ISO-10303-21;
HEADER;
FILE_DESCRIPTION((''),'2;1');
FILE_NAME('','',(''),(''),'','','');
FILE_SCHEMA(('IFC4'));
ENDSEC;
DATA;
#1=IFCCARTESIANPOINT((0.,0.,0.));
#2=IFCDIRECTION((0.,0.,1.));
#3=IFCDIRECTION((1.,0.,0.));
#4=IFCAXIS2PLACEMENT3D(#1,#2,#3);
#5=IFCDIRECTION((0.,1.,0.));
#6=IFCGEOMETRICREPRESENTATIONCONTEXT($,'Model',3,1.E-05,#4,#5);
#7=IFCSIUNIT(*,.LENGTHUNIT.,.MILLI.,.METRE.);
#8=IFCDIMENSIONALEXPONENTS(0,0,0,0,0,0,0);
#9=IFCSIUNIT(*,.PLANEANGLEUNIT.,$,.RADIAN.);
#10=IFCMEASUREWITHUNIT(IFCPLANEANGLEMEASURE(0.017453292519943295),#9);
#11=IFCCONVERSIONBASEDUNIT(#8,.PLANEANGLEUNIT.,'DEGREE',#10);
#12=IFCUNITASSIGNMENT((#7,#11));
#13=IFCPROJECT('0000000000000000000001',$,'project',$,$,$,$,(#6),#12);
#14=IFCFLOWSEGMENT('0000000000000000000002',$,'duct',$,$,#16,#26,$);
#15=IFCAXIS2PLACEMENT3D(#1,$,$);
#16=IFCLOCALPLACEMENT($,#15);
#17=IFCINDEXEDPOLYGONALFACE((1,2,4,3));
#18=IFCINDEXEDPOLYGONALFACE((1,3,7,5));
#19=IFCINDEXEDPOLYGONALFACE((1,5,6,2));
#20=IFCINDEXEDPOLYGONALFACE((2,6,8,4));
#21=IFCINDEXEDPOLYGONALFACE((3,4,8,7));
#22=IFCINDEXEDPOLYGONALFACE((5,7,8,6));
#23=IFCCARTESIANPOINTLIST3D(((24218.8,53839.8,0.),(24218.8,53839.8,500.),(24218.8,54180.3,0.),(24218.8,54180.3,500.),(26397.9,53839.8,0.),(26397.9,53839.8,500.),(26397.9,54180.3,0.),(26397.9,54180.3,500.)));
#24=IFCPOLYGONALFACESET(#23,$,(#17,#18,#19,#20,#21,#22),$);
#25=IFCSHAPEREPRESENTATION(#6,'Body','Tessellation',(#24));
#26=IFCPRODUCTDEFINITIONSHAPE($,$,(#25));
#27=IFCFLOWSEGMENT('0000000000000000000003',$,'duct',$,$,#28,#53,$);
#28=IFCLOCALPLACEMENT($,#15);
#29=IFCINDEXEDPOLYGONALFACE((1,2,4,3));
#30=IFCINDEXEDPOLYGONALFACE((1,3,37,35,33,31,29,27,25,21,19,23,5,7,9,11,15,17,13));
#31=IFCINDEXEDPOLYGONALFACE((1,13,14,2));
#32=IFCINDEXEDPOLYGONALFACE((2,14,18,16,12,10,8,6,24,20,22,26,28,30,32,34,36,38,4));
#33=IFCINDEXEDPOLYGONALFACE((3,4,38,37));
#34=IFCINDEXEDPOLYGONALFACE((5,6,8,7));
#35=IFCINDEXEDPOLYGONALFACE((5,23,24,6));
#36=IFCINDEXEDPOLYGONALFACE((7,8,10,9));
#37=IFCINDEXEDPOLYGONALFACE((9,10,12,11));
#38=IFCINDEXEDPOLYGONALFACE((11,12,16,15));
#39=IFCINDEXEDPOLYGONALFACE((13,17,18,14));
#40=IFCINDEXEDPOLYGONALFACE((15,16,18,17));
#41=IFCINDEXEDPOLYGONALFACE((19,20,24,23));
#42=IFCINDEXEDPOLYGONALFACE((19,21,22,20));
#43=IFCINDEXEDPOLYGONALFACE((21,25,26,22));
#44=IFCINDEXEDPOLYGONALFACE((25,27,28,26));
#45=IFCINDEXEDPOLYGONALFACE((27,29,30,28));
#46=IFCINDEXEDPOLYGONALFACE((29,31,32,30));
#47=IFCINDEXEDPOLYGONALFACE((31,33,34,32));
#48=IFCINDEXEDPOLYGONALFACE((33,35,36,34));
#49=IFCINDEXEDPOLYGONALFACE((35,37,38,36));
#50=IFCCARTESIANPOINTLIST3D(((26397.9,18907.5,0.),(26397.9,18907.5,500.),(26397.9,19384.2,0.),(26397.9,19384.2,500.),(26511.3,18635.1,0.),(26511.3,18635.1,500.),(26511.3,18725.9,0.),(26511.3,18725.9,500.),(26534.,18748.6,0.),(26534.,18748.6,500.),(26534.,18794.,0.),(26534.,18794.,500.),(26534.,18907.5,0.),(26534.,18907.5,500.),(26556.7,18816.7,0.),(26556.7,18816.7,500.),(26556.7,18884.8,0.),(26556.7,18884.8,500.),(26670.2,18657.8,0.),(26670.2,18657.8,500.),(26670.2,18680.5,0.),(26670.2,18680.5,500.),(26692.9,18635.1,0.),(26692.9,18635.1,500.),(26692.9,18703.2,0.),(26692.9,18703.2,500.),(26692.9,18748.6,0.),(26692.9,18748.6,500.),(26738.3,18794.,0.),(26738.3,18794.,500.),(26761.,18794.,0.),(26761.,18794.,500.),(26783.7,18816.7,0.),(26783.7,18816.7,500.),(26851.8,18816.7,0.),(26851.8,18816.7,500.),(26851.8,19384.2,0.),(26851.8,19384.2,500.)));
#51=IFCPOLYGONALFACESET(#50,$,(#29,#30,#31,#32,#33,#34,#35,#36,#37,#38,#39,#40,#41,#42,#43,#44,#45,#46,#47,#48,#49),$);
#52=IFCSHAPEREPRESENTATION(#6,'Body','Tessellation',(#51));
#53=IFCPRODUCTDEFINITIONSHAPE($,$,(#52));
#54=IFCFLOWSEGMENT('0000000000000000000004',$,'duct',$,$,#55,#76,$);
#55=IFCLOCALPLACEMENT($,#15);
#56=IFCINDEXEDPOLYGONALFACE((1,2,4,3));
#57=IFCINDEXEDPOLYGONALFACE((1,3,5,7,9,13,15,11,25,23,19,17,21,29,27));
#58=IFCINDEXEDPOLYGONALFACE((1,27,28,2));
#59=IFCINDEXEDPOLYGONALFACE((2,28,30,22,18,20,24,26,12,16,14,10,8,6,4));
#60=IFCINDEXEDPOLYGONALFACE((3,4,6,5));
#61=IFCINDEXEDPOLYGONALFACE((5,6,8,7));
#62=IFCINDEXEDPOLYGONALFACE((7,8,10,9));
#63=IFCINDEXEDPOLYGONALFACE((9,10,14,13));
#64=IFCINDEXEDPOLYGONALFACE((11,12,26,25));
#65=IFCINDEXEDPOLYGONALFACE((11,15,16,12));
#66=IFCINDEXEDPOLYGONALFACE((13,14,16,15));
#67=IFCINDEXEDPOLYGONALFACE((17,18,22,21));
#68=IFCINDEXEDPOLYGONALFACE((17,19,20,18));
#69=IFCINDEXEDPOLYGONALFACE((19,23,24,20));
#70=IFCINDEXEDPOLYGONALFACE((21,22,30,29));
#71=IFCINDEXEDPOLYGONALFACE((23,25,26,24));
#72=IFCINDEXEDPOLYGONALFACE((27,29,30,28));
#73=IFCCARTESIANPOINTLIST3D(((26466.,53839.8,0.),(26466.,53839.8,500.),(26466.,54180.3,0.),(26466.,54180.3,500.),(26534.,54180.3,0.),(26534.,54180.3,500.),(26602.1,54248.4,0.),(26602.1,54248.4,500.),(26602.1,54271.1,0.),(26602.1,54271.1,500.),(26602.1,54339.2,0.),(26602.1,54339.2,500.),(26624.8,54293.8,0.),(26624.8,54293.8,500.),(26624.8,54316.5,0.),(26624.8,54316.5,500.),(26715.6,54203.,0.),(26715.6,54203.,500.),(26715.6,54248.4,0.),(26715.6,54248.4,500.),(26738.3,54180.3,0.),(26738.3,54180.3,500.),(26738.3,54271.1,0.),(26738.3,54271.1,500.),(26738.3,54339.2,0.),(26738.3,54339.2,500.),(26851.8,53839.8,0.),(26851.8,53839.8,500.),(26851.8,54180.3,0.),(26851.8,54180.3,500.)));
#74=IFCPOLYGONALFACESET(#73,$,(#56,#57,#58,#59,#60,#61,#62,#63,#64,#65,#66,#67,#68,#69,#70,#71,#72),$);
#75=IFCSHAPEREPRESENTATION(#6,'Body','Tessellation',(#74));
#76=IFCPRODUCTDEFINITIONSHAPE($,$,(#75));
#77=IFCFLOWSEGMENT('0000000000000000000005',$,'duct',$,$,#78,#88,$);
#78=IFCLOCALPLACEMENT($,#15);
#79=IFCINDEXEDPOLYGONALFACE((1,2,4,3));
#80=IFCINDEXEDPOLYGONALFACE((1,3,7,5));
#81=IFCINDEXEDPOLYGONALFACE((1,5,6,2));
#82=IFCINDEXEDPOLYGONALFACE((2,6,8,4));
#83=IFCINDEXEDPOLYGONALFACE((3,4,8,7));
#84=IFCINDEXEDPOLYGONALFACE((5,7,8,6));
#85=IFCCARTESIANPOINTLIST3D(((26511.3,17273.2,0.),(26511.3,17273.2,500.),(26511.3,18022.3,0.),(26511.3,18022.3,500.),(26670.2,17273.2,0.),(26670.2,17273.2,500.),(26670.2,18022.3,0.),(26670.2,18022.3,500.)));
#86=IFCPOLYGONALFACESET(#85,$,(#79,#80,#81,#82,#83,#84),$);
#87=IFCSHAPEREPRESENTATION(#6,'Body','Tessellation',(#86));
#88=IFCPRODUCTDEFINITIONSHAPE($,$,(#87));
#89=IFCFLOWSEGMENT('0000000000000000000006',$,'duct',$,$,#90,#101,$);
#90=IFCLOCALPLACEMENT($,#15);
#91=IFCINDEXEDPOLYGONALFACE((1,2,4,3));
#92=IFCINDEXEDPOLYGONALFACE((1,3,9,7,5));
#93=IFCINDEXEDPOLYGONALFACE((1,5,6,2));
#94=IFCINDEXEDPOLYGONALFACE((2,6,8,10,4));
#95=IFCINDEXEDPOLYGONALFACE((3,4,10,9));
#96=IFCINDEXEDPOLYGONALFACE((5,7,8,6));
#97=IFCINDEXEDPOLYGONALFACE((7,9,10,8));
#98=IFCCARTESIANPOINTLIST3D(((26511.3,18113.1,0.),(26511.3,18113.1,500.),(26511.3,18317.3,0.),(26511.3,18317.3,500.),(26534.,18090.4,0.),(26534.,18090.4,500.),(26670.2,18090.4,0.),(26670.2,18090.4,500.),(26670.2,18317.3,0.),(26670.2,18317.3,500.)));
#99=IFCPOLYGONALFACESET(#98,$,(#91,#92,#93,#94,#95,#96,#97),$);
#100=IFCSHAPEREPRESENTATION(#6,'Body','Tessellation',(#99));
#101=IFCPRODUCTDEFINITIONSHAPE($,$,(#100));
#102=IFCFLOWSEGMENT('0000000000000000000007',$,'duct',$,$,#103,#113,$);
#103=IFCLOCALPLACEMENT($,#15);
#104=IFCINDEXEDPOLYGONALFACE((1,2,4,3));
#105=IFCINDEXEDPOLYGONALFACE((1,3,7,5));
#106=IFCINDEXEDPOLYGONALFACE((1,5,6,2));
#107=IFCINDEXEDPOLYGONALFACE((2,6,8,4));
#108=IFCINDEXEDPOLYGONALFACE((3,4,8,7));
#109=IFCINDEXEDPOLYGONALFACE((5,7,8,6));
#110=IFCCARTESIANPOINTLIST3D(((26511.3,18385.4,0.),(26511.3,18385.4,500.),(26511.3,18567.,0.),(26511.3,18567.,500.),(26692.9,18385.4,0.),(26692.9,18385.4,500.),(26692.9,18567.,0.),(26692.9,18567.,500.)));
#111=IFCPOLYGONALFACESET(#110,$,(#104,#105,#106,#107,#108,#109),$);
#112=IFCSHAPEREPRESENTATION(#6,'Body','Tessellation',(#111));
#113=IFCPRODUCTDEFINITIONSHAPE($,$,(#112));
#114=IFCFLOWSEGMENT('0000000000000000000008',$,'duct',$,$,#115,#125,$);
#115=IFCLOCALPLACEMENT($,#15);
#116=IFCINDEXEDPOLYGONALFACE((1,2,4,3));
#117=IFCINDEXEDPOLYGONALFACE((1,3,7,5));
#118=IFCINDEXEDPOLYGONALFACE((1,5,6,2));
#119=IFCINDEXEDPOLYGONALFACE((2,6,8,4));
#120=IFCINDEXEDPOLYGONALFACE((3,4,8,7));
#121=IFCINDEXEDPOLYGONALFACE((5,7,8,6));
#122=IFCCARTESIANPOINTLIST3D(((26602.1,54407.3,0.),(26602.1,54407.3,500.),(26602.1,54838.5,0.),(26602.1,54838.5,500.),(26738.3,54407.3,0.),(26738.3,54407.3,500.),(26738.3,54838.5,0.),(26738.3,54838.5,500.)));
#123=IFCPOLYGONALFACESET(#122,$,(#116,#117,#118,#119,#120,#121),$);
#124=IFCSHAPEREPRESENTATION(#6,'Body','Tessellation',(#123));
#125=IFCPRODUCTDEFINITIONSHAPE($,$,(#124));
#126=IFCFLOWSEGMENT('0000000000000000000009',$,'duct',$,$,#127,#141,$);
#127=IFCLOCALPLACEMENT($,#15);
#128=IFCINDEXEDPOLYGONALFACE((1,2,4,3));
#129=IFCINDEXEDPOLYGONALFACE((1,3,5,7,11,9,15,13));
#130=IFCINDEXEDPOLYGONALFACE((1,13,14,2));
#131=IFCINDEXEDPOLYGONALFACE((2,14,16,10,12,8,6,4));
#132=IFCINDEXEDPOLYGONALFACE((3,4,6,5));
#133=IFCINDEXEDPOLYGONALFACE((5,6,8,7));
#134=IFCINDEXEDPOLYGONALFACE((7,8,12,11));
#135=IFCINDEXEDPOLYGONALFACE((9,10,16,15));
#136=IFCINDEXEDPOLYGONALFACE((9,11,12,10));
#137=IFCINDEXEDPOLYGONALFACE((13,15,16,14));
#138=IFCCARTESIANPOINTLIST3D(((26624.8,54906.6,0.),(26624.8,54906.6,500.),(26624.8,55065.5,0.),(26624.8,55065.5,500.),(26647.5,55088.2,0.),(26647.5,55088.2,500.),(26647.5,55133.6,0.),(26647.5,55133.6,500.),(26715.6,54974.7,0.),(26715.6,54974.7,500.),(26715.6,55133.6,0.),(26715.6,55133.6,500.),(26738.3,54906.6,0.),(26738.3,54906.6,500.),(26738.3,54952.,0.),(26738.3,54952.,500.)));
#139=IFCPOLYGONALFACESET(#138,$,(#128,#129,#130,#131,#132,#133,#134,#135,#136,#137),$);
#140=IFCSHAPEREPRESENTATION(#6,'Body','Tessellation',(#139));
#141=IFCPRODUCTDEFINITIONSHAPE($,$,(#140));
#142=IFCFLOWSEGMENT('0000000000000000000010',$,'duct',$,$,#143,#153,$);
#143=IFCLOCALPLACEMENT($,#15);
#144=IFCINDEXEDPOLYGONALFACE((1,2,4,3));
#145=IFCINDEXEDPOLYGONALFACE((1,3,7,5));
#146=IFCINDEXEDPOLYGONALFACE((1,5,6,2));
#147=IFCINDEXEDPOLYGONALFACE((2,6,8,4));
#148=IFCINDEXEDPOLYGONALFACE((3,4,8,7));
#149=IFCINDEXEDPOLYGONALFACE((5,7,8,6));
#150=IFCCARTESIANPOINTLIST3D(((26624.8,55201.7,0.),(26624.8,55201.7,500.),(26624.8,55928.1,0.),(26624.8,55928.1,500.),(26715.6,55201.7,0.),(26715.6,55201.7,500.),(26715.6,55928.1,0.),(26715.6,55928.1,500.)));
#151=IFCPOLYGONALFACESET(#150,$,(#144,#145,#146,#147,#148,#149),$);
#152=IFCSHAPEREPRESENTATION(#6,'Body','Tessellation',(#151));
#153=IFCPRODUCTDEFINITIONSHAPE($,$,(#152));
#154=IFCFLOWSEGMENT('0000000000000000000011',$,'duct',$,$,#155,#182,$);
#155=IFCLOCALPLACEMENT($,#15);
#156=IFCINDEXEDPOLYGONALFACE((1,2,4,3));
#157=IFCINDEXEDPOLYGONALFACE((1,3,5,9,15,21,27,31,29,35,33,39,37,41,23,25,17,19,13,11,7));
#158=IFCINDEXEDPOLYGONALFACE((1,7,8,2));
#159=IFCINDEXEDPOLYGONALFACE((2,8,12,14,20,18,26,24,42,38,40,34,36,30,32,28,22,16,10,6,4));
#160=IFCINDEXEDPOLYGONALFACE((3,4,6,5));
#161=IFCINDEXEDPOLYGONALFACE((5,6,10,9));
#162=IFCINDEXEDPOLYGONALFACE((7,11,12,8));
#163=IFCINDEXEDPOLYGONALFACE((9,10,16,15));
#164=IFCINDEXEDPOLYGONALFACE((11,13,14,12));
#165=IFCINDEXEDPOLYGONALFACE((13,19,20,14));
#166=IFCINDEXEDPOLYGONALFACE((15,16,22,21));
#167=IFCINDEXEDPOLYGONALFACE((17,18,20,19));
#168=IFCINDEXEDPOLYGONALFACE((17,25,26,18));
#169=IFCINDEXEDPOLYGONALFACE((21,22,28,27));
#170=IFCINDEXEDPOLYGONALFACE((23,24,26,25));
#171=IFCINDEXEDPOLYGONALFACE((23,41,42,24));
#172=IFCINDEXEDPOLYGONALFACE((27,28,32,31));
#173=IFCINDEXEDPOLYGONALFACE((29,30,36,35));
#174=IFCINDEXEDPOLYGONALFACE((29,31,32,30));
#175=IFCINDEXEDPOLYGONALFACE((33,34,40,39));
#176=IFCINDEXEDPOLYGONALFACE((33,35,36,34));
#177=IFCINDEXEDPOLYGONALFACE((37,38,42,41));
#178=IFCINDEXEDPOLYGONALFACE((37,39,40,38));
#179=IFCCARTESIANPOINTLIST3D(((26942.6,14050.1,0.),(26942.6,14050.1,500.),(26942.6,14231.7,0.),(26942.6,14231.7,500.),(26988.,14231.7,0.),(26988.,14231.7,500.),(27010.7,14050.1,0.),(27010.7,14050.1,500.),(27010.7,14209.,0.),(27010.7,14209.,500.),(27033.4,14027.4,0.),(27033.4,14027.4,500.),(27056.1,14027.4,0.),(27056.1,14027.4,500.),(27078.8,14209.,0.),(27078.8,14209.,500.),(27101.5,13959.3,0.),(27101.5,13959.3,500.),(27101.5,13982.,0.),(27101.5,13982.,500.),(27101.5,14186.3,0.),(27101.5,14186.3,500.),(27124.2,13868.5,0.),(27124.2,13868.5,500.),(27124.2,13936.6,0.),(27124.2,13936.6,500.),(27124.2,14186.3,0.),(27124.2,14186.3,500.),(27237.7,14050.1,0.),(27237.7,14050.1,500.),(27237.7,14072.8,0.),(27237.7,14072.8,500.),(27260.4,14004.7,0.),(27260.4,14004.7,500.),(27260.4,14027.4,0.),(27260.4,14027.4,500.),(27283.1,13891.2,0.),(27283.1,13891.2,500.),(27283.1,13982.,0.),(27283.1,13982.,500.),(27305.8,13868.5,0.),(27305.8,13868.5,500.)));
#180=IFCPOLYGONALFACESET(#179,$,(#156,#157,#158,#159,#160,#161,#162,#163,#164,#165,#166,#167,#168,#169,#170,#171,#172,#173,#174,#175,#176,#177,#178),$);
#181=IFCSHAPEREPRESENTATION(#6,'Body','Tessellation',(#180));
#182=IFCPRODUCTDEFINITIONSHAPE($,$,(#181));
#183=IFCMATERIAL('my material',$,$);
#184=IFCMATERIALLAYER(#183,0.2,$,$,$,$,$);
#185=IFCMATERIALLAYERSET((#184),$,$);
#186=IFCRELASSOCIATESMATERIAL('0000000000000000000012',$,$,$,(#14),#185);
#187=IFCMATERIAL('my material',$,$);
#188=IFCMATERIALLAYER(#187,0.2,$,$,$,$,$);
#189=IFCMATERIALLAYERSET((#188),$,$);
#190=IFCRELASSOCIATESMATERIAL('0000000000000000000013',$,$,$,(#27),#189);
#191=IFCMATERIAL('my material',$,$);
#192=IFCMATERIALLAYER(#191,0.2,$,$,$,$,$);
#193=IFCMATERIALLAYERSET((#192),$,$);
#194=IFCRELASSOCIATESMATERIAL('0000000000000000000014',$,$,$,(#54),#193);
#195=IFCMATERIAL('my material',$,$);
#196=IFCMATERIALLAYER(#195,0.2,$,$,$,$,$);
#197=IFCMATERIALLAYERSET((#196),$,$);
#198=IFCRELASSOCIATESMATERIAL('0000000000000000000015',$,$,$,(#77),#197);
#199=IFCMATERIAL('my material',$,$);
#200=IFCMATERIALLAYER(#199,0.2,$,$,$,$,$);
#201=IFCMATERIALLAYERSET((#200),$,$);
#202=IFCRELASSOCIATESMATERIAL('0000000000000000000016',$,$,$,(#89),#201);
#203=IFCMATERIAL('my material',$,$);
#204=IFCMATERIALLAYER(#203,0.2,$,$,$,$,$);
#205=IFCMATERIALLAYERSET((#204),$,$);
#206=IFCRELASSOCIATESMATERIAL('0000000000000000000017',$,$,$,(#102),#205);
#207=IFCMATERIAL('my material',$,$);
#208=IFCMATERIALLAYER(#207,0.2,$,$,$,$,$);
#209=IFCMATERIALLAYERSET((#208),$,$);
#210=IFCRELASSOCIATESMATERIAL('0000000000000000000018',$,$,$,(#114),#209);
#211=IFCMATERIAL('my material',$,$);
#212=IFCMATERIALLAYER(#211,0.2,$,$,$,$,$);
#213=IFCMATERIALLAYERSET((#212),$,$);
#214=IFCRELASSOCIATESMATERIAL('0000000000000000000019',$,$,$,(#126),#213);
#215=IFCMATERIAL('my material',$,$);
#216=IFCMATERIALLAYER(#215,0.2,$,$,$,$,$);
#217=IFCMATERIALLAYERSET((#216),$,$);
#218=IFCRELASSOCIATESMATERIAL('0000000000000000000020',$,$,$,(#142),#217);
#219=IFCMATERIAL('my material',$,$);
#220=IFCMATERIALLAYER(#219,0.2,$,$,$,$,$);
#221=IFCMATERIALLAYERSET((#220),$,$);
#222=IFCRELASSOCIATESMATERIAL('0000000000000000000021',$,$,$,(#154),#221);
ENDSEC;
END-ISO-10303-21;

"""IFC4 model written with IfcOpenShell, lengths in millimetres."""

from ifc_helpers import new_model, entity, si_unit, converted_unit, direction, origin_with_axes, place, context, project, polyline, outline, extrude, material, layer, layer_set, layer_usage, element, save


model = new_model("IFC4")

# Units and contexts
model_context = context("Model", 3, precision=1e-05, world=origin_with_axes(), true_north=direction((0.0, 1.0, 0.0)))
ifc_project = project(units=[si_unit("LENGTHUNIT", "METRE", prefix="MILLI"), converted_unit("PLANEANGLEUNIT", "DEGREE", entity("IfcPlaneAngleMeasure", 0.017453292519943295), si_unit("PLANEANGLEUNIT", "RADIAN"), dimensions=[0, 0, 0, 0, 0, 0, 0])], contexts=[model_context])

# Flow segments
ifc_material_1 = material(Name="my material")
ifc_layer_1 = layer(ifc_material_1, 0.2)
ifc_layer_set_1 = layer_set([ifc_layer_1])
ifc_layer_usage_1 = layer_usage(ifc_layer_set_1, "AXIS2", "POSITIVE", -0.1)
flow_segment_1_placement = place(None, origin_with_axes())
element("IfcFlowSegment", 1, at=flow_segment_1_placement, material=ifc_layer_usage_1, Name="duct", context=model_context, shape_type="SweptSolid", body=[
    extrude(outline(polyline([(24218.8, 53839.8), (26397.9, 53839.8), (26397.9, 54180.3), (24218.8, 54180.3), (24218.8, 53839.8)])), origin_with_axes(), (0.0, 0.0, 1.0), 500.0),
])
ifc_material_2 = material(Name="my material")
ifc_layer_2 = layer(ifc_material_2, 0.2)
ifc_layer_set_2 = layer_set([ifc_layer_2])
ifc_layer_usage_2 = layer_usage(ifc_layer_set_2, "AXIS2", "POSITIVE", -0.1)
flow_segment_2_placement = place(None, origin_with_axes())
element("IfcFlowSegment", 2, at=flow_segment_2_placement, material=ifc_layer_usage_2, Name="duct", context=model_context, shape_type="SweptSolid", body=[
    extrude(outline(polyline([(26397.9, 18907.5), (26534.0, 18907.5), (26556.7, 18884.8), (26556.7, 18816.7), (26534.0, 18794.0), (26534.0, 18748.6), (26511.3, 18725.9), (26511.3, 18635.1), (26692.9, 18635.1), (26670.2, 18657.8), (26670.2, 18680.5), (26692.9, 18703.2), (26692.9, 18748.6), (26738.3, 18794.0), (26761.0, 18794.0), (26783.7, 18816.7), (26851.8, 18816.7), (26851.8, 19384.2), (26397.9, 19384.2), (26397.9, 18907.5)])), origin_with_axes(), (0.0, 0.0, 1.0), 500.0),
])
ifc_material_3 = material(Name="my material")
ifc_layer_3 = layer(ifc_material_3, 0.2)
ifc_layer_set_3 = layer_set([ifc_layer_3])
ifc_layer_usage_3 = layer_usage(ifc_layer_set_3, "AXIS2", "POSITIVE", -0.1)
flow_segment_3_placement = place(None, origin_with_axes())
element("IfcFlowSegment", 3, at=flow_segment_3_placement, material=ifc_layer_usage_3, Name="duct", context=model_context, shape_type="SweptSolid", body=[
    extrude(outline(polyline([(26466.0, 53839.8), (26851.8, 53839.8), (26851.8, 54180.3), (26738.3, 54180.3), (26715.6, 54203.0), (26715.6, 54248.4), (26738.3, 54271.1), (26738.3, 54339.2), (26602.1, 54339.2), (26624.8, 54316.5), (26624.8, 54293.8), (26602.1, 54271.1), (26602.1, 54248.4), (26534.0, 54180.3), (26466.0, 54180.3), (26466.0, 53839.8)])), origin_with_axes(), (0.0, 0.0, 1.0), 500.0),
])
ifc_material_4 = material(Name="my material")
ifc_layer_4 = layer(ifc_material_4, 0.2)
ifc_layer_set_4 = layer_set([ifc_layer_4])
ifc_layer_usage_4 = layer_usage(ifc_layer_set_4, "AXIS2", "POSITIVE", -0.1)
flow_segment_4_placement = place(None, origin_with_axes())
element("IfcFlowSegment", 4, at=flow_segment_4_placement, material=ifc_layer_usage_4, Name="duct", context=model_context, shape_type="SweptSolid", body=[
    extrude(outline(polyline([(26511.3, 17273.2), (26670.2, 17273.2), (26670.2, 18022.3), (26511.3, 18022.3), (26511.3, 17273.2)])), origin_with_axes(), (0.0, 0.0, 1.0), 500.0),
])
ifc_material_5 = material(Name="my material")
ifc_layer_5 = layer(ifc_material_5, 0.2)
ifc_layer_set_5 = layer_set([ifc_layer_5])
ifc_layer_usage_5 = layer_usage(ifc_layer_set_5, "AXIS2", "POSITIVE", -0.1)
flow_segment_5_placement = place(None, origin_with_axes())
element("IfcFlowSegment", 5, at=flow_segment_5_placement, material=ifc_layer_usage_5, Name="duct", context=model_context, shape_type="SweptSolid", body=[
    extrude(outline(polyline([(26511.3, 18113.1), (26534.0, 18090.4), (26670.2, 18090.4), (26670.2, 18317.3), (26511.3, 18317.3), (26511.3, 18113.1)])), origin_with_axes(), (0.0, 0.0, 1.0), 500.0),
])
ifc_material_6 = material(Name="my material")
ifc_layer_6 = layer(ifc_material_6, 0.2)
ifc_layer_set_6 = layer_set([ifc_layer_6])
ifc_layer_usage_6 = layer_usage(ifc_layer_set_6, "AXIS2", "POSITIVE", -0.1)
flow_segment_6_placement = place(None, origin_with_axes())
element("IfcFlowSegment", 6, at=flow_segment_6_placement, material=ifc_layer_usage_6, Name="duct", context=model_context, shape_type="SweptSolid", body=[
    extrude(outline(polyline([(26511.3, 18385.4), (26692.9, 18385.4), (26692.9, 18567.0), (26511.3, 18567.0), (26511.3, 18385.4)])), origin_with_axes(), (0.0, 0.0, 1.0), 500.0),
])
ifc_material_7 = material(Name="my material")
ifc_layer_7 = layer(ifc_material_7, 0.2)
ifc_layer_set_7 = layer_set([ifc_layer_7])
ifc_layer_usage_7 = layer_usage(ifc_layer_set_7, "AXIS2", "POSITIVE", -0.1)
flow_segment_7_placement = place(None, origin_with_axes())
element("IfcFlowSegment", 7, at=flow_segment_7_placement, material=ifc_layer_usage_7, Name="duct", context=model_context, shape_type="SweptSolid", body=[
    extrude(outline(polyline([(26602.1, 54407.3), (26738.3, 54407.3), (26738.3, 54838.5), (26602.1, 54838.5), (26602.1, 54407.3)])), origin_with_axes(), (0.0, 0.0, 1.0), 500.0),
])
ifc_material_8 = material(Name="my material")
ifc_layer_8 = layer(ifc_material_8, 0.2)
ifc_layer_set_8 = layer_set([ifc_layer_8])
ifc_layer_usage_8 = layer_usage(ifc_layer_set_8, "AXIS2", "POSITIVE", -0.1)
flow_segment_8_placement = place(None, origin_with_axes())
element("IfcFlowSegment", 8, at=flow_segment_8_placement, material=ifc_layer_usage_8, Name="duct", context=model_context, shape_type="SweptSolid", body=[
    extrude(outline(polyline([(26624.8, 54906.6), (26738.3, 54906.6), (26738.3, 54952.0), (26715.6, 54974.7), (26715.6, 55133.6), (26647.5, 55133.6), (26647.5, 55088.2), (26624.8, 55065.5), (26624.8, 54906.6)])), origin_with_axes(), (0.0, 0.0, 1.0), 500.0),
])
ifc_material_9 = material(Name="my material")
ifc_layer_9 = layer(ifc_material_9, 0.2)
ifc_layer_set_9 = layer_set([ifc_layer_9])
ifc_layer_usage_9 = layer_usage(ifc_layer_set_9, "AXIS2", "POSITIVE", -0.1)
flow_segment_9_placement = place(None, origin_with_axes())
element("IfcFlowSegment", 9, at=flow_segment_9_placement, material=ifc_layer_usage_9, Name="duct", context=model_context, shape_type="SweptSolid", body=[
    extrude(outline(polyline([(26624.8, 55201.7), (26715.6, 55201.7), (26715.6, 55928.1), (26624.8, 55928.1), (26624.8, 55201.7)])), origin_with_axes(), (0.0, 0.0, 1.0), 500.0),
])
ifc_material_10 = material(Name="my material")
ifc_layer_10 = layer(ifc_material_10, 0.2)
ifc_layer_set_10 = layer_set([ifc_layer_10])
ifc_layer_usage_10 = layer_usage(ifc_layer_set_10, "AXIS2", "POSITIVE", -0.1)
flow_segment_10_placement = place(None, origin_with_axes())
element("IfcFlowSegment", 10, at=flow_segment_10_placement, material=ifc_layer_usage_10, Name="duct", context=model_context, shape_type="SweptSolid", body=[
    extrude(outline(polyline([(26942.6, 14050.1), (27010.7, 14050.1), (27033.4, 14027.4), (27056.1, 14027.4), (27101.5, 13982.0), (27101.5, 13959.3), (27124.2, 13936.6), (27124.2, 13868.5), (27305.8, 13868.5), (27283.1, 13891.2), (27283.1, 13982.0), (27260.4, 14004.7), (27260.4, 14027.4), (27237.7, 14050.1), (27237.7, 14072.8), (27124.2, 14186.3), (27101.5, 14186.3), (27078.8, 14209.0), (27010.7, 14209.0), (26988.0, 14231.7), (26942.6, 14231.7), (26942.6, 14050.1)])), origin_with_axes(), (0.0, 0.0, 1.0), 500.0),
])

save(model, "model.ifc")
